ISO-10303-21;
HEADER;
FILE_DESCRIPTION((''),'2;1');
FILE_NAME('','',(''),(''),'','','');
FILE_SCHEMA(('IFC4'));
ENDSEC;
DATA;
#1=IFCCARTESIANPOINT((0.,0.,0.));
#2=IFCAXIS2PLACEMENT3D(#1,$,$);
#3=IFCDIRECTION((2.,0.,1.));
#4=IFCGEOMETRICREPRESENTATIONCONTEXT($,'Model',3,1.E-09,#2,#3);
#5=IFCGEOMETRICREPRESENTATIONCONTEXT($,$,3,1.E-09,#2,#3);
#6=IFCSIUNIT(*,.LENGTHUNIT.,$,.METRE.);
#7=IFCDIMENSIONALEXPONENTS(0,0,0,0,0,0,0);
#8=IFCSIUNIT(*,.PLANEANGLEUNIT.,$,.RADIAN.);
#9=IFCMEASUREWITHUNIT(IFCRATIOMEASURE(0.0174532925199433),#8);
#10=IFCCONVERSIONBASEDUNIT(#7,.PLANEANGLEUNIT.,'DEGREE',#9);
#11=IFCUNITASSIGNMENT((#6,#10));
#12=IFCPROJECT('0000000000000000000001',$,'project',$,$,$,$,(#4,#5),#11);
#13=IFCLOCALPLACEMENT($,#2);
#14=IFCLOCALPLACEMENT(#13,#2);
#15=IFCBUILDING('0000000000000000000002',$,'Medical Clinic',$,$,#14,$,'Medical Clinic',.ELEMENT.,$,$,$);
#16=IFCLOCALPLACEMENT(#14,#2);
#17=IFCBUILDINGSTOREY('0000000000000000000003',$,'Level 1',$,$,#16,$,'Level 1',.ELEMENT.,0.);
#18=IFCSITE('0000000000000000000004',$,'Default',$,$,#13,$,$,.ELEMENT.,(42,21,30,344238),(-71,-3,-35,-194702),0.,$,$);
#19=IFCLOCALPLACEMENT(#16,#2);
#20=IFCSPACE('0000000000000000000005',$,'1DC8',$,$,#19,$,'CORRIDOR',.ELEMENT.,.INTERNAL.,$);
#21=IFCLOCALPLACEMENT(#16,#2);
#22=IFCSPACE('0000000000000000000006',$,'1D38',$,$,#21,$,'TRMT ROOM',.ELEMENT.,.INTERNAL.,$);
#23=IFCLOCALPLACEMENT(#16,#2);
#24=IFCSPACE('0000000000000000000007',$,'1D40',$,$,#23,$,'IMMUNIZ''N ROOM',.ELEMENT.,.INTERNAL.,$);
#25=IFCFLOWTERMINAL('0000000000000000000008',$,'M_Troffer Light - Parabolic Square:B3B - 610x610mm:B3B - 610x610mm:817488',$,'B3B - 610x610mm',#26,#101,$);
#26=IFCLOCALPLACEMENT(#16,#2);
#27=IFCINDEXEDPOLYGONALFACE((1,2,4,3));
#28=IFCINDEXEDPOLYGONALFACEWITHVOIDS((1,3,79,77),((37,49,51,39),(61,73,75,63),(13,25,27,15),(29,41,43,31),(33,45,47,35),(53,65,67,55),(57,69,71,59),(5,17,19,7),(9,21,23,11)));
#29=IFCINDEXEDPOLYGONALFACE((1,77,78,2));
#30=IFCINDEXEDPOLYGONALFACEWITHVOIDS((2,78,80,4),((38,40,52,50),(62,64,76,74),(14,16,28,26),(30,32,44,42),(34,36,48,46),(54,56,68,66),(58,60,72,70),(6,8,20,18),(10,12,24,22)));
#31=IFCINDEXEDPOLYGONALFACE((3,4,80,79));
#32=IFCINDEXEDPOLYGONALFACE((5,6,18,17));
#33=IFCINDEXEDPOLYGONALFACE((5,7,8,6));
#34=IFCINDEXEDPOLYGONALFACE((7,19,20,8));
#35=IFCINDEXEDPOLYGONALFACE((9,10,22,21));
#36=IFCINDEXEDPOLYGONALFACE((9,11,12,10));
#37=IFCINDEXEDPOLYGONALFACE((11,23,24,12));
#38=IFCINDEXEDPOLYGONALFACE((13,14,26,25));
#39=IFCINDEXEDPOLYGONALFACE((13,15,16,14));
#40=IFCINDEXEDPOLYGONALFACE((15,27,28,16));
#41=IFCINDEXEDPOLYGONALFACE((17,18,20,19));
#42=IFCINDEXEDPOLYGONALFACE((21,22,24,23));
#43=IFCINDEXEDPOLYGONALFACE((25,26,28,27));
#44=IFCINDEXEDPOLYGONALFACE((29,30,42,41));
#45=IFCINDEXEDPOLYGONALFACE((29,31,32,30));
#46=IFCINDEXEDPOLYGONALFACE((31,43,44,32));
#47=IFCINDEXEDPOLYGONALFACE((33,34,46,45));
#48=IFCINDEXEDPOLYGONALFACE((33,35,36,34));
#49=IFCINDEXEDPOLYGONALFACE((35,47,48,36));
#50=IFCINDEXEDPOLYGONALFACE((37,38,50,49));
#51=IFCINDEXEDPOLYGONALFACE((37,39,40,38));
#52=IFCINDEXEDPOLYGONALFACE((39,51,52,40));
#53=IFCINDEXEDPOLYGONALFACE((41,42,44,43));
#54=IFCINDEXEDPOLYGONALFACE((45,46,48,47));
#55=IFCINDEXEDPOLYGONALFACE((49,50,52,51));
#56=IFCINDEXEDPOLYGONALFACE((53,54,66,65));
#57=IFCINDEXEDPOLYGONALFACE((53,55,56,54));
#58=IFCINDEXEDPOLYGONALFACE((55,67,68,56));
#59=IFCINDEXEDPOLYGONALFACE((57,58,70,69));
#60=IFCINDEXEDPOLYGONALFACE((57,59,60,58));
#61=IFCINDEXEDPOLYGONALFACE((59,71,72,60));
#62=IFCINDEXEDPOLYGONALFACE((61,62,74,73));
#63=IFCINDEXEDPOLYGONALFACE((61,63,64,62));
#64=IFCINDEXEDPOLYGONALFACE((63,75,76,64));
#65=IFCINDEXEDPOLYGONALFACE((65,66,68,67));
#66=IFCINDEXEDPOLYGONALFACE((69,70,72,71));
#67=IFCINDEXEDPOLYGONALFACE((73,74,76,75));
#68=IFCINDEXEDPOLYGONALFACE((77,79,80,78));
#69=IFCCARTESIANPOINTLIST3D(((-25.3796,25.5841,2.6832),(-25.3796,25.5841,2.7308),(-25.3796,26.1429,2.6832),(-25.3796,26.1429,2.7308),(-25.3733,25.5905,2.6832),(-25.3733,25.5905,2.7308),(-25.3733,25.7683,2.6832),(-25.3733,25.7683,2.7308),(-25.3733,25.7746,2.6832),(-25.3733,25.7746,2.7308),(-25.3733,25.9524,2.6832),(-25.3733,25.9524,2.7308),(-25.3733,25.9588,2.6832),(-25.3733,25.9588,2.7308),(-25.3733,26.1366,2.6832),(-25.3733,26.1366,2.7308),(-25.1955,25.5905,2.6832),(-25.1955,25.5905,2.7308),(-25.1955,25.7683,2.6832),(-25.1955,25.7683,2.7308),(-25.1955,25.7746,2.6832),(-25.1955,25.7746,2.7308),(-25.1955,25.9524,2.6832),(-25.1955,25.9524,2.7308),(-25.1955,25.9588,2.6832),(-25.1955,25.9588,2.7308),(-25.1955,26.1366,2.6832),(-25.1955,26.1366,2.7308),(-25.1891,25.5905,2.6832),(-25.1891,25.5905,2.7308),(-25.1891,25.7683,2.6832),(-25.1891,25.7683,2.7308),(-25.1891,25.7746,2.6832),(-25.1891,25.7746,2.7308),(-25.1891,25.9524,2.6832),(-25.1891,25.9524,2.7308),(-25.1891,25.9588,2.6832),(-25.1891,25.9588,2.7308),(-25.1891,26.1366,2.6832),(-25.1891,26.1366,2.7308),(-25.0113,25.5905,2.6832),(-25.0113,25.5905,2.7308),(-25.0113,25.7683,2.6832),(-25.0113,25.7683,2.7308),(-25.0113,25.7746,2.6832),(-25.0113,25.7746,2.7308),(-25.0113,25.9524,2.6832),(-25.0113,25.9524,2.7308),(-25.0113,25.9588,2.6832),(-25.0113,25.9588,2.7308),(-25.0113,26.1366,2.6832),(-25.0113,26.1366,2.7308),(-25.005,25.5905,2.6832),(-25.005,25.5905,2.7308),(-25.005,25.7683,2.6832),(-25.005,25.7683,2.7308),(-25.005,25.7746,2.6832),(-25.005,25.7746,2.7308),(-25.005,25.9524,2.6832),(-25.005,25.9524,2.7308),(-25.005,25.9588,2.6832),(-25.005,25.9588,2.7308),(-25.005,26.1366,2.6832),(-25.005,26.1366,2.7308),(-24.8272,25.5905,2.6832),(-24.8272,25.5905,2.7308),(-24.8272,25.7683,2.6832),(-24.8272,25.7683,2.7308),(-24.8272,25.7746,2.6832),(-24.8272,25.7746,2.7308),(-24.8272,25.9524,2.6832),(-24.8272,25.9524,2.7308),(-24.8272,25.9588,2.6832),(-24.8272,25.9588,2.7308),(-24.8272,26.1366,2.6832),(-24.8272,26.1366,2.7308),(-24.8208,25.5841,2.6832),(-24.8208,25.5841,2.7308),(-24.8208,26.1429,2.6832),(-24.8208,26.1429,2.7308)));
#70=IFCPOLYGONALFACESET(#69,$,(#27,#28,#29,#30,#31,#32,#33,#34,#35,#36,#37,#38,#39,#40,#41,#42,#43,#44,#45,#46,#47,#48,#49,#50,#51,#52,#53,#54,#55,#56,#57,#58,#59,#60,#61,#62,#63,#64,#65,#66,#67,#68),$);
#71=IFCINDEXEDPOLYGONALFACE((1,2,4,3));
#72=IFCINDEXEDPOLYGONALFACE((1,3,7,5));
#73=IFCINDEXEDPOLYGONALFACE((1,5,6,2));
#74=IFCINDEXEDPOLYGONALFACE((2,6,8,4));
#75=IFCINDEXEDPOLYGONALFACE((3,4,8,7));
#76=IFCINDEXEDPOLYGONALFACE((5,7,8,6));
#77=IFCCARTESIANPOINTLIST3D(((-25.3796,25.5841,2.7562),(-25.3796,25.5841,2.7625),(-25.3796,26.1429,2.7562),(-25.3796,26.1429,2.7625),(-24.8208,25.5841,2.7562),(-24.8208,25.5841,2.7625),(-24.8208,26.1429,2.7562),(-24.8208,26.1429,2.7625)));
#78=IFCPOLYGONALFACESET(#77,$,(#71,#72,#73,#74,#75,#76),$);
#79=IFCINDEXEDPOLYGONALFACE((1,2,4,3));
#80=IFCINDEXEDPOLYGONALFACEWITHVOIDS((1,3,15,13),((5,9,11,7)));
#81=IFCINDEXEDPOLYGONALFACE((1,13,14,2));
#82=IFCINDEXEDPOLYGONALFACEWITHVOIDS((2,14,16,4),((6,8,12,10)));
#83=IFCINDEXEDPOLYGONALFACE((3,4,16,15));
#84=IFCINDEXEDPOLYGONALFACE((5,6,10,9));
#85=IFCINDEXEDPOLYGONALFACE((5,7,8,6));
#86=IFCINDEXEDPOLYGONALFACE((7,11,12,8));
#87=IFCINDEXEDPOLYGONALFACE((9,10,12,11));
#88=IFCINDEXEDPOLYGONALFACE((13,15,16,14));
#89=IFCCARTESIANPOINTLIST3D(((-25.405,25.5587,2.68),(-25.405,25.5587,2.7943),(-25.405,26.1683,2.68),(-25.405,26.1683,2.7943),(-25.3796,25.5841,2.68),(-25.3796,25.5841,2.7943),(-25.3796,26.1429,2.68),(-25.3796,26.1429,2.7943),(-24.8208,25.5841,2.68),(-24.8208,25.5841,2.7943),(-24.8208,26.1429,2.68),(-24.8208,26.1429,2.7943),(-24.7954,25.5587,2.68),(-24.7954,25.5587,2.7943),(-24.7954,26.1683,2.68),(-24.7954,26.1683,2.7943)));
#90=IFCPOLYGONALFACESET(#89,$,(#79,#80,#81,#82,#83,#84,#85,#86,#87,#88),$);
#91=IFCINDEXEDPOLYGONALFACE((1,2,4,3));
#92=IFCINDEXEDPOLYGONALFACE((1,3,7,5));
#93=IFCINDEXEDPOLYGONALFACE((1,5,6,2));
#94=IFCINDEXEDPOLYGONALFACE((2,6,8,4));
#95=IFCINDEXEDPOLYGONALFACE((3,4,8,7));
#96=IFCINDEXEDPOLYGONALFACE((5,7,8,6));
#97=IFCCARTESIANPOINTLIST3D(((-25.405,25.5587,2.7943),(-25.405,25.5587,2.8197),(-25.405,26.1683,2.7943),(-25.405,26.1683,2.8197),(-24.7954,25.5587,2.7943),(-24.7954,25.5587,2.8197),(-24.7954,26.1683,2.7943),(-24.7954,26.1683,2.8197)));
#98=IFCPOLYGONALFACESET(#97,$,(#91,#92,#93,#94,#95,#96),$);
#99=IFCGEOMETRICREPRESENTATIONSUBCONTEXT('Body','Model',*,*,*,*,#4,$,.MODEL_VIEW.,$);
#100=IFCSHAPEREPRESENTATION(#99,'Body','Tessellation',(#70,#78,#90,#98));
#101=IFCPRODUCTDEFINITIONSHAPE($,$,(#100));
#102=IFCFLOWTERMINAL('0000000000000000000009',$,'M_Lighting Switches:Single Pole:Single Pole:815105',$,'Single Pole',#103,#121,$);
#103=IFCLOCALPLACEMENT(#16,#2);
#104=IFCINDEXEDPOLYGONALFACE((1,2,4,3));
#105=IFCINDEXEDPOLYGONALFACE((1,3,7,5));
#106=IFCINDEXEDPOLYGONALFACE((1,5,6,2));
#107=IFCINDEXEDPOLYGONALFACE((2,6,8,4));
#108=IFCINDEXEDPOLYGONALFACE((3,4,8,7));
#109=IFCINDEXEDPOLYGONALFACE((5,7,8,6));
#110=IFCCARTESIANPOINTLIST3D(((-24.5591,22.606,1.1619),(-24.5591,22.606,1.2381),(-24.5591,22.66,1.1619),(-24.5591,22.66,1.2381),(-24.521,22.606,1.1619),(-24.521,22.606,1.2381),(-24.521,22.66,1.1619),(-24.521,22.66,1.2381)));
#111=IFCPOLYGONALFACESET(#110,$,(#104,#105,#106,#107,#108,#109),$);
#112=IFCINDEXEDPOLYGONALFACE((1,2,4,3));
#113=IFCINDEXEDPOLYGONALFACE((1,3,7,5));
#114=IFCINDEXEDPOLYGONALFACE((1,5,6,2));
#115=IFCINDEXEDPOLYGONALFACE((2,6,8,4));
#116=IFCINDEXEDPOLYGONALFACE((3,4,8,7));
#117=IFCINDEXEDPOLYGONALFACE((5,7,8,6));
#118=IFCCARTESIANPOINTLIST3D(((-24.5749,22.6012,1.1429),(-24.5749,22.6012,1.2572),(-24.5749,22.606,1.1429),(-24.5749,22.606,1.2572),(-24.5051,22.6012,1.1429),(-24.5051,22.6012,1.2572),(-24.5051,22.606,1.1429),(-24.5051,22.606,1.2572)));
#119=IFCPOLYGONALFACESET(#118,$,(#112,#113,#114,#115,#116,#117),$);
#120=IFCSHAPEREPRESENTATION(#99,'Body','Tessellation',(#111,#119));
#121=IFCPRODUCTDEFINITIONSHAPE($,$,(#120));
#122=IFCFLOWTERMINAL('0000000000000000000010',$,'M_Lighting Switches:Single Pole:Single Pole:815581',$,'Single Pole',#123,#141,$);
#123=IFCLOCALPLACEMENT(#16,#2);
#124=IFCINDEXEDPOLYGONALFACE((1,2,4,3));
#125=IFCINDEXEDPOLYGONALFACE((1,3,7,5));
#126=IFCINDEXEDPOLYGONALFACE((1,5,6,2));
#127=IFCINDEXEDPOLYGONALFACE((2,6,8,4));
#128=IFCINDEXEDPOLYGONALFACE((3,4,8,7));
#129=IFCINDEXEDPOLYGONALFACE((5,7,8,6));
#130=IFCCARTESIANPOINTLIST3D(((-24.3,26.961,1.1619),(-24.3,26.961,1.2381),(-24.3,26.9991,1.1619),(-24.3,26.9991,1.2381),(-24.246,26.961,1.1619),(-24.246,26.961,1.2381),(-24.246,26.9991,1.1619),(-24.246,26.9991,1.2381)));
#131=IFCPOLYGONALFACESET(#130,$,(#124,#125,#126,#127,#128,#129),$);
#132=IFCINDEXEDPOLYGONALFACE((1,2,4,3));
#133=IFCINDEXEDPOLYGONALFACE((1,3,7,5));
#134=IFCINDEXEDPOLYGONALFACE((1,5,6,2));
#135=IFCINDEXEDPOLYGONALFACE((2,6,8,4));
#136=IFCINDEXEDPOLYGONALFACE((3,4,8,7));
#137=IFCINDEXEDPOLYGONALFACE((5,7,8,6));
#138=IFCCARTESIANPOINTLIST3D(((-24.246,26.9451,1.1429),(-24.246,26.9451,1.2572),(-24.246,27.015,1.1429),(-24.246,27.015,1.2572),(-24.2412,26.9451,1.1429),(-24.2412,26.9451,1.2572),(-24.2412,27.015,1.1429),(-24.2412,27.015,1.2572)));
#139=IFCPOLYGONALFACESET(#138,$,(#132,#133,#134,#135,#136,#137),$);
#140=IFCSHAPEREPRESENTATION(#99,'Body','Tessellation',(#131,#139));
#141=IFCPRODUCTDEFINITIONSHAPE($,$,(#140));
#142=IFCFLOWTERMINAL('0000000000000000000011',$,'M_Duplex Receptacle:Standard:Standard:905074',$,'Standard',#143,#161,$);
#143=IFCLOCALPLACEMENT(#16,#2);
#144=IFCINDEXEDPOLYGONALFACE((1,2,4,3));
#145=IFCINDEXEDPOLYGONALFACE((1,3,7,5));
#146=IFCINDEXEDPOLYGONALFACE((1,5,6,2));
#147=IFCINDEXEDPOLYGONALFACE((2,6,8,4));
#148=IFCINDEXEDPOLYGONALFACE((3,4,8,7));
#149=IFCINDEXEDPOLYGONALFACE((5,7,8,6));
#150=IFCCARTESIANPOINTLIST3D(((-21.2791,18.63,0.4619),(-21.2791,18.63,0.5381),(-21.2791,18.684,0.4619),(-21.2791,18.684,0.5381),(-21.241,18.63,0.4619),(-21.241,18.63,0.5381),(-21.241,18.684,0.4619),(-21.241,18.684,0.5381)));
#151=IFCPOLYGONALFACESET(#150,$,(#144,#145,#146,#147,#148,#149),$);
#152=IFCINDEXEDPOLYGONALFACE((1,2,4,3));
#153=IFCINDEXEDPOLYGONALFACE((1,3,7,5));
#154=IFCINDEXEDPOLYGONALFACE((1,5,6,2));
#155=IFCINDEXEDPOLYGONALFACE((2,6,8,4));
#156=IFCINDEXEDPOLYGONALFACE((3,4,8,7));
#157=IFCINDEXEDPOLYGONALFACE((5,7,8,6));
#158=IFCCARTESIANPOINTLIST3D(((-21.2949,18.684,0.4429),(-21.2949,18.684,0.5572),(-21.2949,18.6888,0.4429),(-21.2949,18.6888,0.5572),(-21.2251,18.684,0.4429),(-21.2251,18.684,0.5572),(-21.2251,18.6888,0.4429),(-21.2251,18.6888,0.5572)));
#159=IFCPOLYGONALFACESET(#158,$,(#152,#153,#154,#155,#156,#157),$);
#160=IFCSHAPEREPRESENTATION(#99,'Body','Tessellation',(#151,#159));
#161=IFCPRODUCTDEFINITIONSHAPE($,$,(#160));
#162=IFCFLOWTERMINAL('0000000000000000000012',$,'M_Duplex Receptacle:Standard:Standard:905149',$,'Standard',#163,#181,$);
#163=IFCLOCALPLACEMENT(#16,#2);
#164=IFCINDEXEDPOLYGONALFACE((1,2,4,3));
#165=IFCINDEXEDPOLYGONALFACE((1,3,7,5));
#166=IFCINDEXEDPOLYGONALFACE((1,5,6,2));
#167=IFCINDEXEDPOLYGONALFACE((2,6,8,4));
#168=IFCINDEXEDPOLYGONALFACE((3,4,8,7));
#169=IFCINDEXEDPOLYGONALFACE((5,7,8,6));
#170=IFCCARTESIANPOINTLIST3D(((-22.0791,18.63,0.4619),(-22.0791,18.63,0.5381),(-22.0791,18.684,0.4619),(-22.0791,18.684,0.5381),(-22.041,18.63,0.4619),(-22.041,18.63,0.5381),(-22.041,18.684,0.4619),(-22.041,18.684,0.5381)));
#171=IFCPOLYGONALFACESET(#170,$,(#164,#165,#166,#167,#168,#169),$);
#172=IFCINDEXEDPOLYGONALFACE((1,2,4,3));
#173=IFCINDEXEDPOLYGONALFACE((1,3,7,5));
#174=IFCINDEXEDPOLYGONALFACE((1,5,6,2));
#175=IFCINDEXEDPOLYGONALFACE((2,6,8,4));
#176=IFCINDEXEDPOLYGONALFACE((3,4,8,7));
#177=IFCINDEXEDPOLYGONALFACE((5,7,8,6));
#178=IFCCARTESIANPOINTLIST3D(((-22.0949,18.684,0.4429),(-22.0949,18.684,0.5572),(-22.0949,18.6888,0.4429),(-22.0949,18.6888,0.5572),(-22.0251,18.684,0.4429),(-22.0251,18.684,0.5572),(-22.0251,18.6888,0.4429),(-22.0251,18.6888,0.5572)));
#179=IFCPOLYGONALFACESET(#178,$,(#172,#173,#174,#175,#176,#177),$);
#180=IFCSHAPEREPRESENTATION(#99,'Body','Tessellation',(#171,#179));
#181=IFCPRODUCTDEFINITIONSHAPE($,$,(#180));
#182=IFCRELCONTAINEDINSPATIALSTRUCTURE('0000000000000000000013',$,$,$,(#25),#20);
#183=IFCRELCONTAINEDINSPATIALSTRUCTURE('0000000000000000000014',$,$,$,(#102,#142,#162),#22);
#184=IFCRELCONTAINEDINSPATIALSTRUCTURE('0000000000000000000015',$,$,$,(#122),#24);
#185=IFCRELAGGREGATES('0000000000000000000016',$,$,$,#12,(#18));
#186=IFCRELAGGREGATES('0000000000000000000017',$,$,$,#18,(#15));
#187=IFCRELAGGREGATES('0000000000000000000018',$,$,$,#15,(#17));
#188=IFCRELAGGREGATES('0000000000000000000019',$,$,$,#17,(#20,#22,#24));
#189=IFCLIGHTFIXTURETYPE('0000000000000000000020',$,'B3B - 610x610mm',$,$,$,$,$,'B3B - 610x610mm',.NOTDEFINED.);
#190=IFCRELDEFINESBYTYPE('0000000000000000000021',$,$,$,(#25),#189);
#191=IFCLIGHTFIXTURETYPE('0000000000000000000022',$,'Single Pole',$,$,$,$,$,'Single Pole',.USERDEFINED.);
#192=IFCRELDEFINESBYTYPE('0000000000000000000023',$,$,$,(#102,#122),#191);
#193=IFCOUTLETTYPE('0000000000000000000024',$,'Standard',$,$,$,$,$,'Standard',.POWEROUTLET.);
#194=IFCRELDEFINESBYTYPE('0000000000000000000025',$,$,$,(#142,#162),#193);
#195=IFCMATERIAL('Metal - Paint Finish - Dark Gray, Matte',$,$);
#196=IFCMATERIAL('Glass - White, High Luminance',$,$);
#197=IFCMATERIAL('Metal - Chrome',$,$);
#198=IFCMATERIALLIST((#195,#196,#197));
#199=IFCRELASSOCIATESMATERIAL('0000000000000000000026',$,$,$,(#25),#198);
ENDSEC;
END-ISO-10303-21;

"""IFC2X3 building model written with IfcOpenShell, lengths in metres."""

from ifc_helpers import new_model, entity, si_unit, converted_unit, direction, frame, frame_2d, origin, origin_2d_with_axis, place, context, subcontext, project, spatial, polyline, rectangle, outline, extrude, source, transform, mapped, material, material_list, type_object, type_shapes, element, save


model = new_model("IFC2X3")

# Units and contexts
model_context = context("Model", 3, precision=1e-09, world=origin(), true_north=direction((2.0, 0.0, 1.0)))
context_of_model = context(None, 3, precision=1e-09, world=origin(), true_north=direction((2.0, 0.0, 1.0)))
body_context = subcontext(model_context, "Body", "Model", "MODEL_VIEW")
ifc_project = project(units=[si_unit("LENGTHUNIT", "METRE"), converted_unit("PLANEANGLEUNIT", "DEGREE", entity("IfcRatioMeasure", 0.0174532925199433), si_unit("PLANEANGLEUNIT", "RADIAN"), dimensions=[0, 0, 0, 0, 0, 0, 0])], contexts=[model_context, context_of_model])

# Site, building, storey
site_placement = place(None, origin())
site = spatial("IfcSite", under=ifc_project, at=site_placement, Name="Default", CompositionType="ELEMENT", RefLatitude=(42, 21, 30, 344238), RefLongitude=(-71, -3, -35, -194702), RefElevation=0.0)
building_placement = place(site_placement, origin())
building = spatial("IfcBuilding", under=site, at=building_placement, Name="Medical Clinic", LongName="Medical Clinic", CompositionType="ELEMENT")
storey_placement = place(building_placement, origin())
storey = spatial("IfcBuildingStorey", under=building, at=storey_placement, Name="Level 1", LongName="Level 1", CompositionType="ELEMENT", Elevation=0.0)

# Shared definitions
ifc_material_1 = material(Name="Metal - Paint Finish - Dark Gray, Matte")
ifc_material_2 = material(Name="Glass - White, High Luminance")
ifc_material_3 = material(Name="Metal - Chrome")

# Shared definitions
space_1_placement = place(storey_placement, origin())
space_1 = spatial("IfcSpace", under=storey, at=space_1_placement, Name="1DC8", LongName="CORRIDOR", CompositionType="ELEMENT", InteriorOrExteriorSpace="INTERNAL")

# Flow terminal
ifc_material_list_1 = material_list([ifc_material_1, ifc_material_2, ifc_material_3])
light_fixture_type_1 = type_object("IfcLightFixtureType", Name="B3B - 610x610mm", ElementType="B3B - 610x610mm", PredefinedType="NOTDEFINED")
shared_shape_1 = source(origin(), body_context, "Body", "SweptSolid", [
    extrude(outline(polyline([(-0.2794, -0.2794), (0.2794, -0.2794), (0.2794, 0.2794), (-0.2794, 0.2794), (-0.2794, -0.2794)]), holes=[polyline([(-0.0952, 0.0953), (-0.273, 0.0953), (-0.273, 0.2731), (-0.0952, 0.2731), (-0.0952, 0.0953)]), polyline([(0.2731, 0.0953), (0.0953, 0.0953), (0.0953, 0.2731), (0.2731, 0.2731), (0.2731, 0.0953)]), polyline([(-0.0889, 0.2731), (0.0889, 0.2731), (0.0889, 0.0953), (-0.0889, 0.0953), (-0.0889, 0.2731)]), polyline([(0.2731, -0.273), (0.0953, -0.273), (0.0953, -0.0952), (0.2731, -0.0952), (0.2731, -0.273)]), polyline([(0.0889, -0.273), (-0.0889, -0.273), (-0.0889, -0.0952), (0.0889, -0.0952), (0.0889, -0.273)]), polyline([(-0.0952, -0.273), (-0.273, -0.273), (-0.273, -0.0952), (-0.0952, -0.0952), (-0.0952, -0.273)]), polyline([(-0.0952, -0.0889), (-0.273, -0.0889), (-0.273, 0.0889), (-0.0952, 0.0889), (-0.0952, -0.0889)]), polyline([(0.0889, -0.0889), (-0.0889, -0.0889), (-0.0889, 0.0889), (0.0889, 0.0889), (0.0889, -0.0889)]), polyline([(0.2731, -0.0889), (0.0953, -0.0889), (0.0953, 0.0889), (0.2731, 0.0889), (0.2731, -0.0889)])]), frame((0.0, -0.3048, -0.0508), z_axis=(0.0, 0.0, 1.0), x_axis=(-1.0, 0.0, 0.0)), (0.0, 0.0, 1.0), 0.0476),
    extrude(rectangle(XDim=0.5588, YDim=0.5588, at=origin_2d_with_axis()), frame((0.0, -0.3048, -0.0825), z_axis=(0.0, 0.0, 1.0), x_axis=(-1.0, 0.0, 0.0)), (0.0, 0.0, 1.0), 0.0064),
    extrude(outline(polyline([(-0.3048, -0.3048), (0.3048, -0.3048), (0.3048, 0.3048), (-0.3048, 0.3048), (-0.3048, -0.3048)]), holes=[polyline([(0.2794, 0.2794), (0.2794, -0.2794), (-0.2794, -0.2794), (-0.2794, 0.2794), (0.2794, 0.2794)])]), frame((0.0, -0.3048, -0.1143)), (0.0, 0.0, 1.0), 0.1143),
    extrude(rectangle(XDim=0.6096, YDim=0.6096, at=origin_2d_with_axis()), frame((0.0, -0.3048, -0.1397), z_axis=(0.0, 0.0, 1.0), x_axis=(-1.0, 0.0, 0.0)), (0.0, 0.0, 1.0), 0.0254),
])
type_shapes(light_fixture_type_1, [shared_shape_1])
flow_terminal_1_placement = place(space_1_placement, frame((-25.1002, 25.5587, 2.68), z_axis=(0.0, 0.0, -1.0), x_axis=(1.0, 0.0, 0.0)))
element("IfcFlowTerminal", 1, at=flow_terminal_1_placement, inside=space_1, type_object=light_fixture_type_1, material=ifc_material_list_1, Name="M_Troffer Light - Parabolic Square:B3B - 610x610mm:B3B - 610x610mm:817488", ObjectType="B3B - 610x610mm", context=body_context, shape_type="MappedRepresentation", body=[
    mapped(shared_shape_1, transform((0.0, 0.0, 0.0), scale=1.0)),
])

# Shared definitions
space_2_placement = place(storey_placement, origin())
space_2 = spatial("IfcSpace", under=storey, at=space_2_placement, Name="1D38", LongName="TRMT ROOM", CompositionType="ELEMENT", InteriorOrExteriorSpace="INTERNAL")

# Flow terminal
light_fixture_type_2 = type_object("IfcLightFixtureType", Name="Single Pole", ElementType="Single Pole", PredefinedType="USERDEFINED")
shared_shape_2 = source(origin(), body_context, "Body", "SweptSolid", [
    extrude(rectangle(XDim=0.0381, YDim=0.0762, at=origin_2d_with_axis()), frame((0.0, 0.0, -0.054), z_axis=(0.0, 0.0, 1.0), x_axis=(-1.0, 0.0, 0.0)), (0.0, 0.0, 1.0), 0.054),
    extrude(rectangle(XDim=0.0698, YDim=0.1143, at=frame_2d((0.0, 0.0), x_axis=(1.0, 0.0))), frame((0.0, 0.0, 0.0), z_axis=(0.0, 0.0, 1.0), x_axis=(-1.0, 0.0, 0.0)), (0.0, 0.0, 1.0), 0.0048),
])
type_shapes(light_fixture_type_2, [shared_shape_2])
flow_terminal_2_placement = place(space_2_placement, frame((-24.54, 22.606, 1.2), z_axis=(0.0, -1.0, 0.0), x_axis=(1.0, 0.0, 0.0)))
element("IfcFlowTerminal", 2, at=flow_terminal_2_placement, inside=space_2, type_object=light_fixture_type_2, Name="M_Lighting Switches:Single Pole:Single Pole:815105", ObjectType="Single Pole", context=body_context, shape_type="MappedRepresentation", body=[
    mapped(shared_shape_2, transform((0.0, 0.0, 0.0), scale=1.0)),
])

# Shared definitions
space_3_placement = place(storey_placement, origin())
space_3 = spatial("IfcSpace", under=storey, at=space_3_placement, Name="1D40", LongName="IMMUNIZ'N ROOM", CompositionType="ELEMENT", InteriorOrExteriorSpace="INTERNAL")

# Flow terminals
flow_terminal_3_placement = place(space_3_placement, frame((-24.246, 26.9801, 1.2), z_axis=(1.0, 0.0, 0.0), x_axis=(0.0, 1.0, 0.0)))
element("IfcFlowTerminal", 3, at=flow_terminal_3_placement, inside=space_3, type_object=light_fixture_type_2, Name="M_Lighting Switches:Single Pole:Single Pole:815581", ObjectType="Single Pole", context=body_context, shape_type="MappedRepresentation", body=[
    mapped(shared_shape_2, transform((0.0, 0.0, 0.0), scale=1.0)),
])
outlet_type = type_object("IfcOutletType", Name="Standard", ElementType="Standard", PredefinedType="POWEROUTLET")
shared_shape_3 = source(origin(), body_context, "Body", "SweptSolid", [
    extrude(rectangle(XDim=0.0381, YDim=0.0762, at=origin_2d_with_axis()), frame((0.0, 0.0, -0.054), z_axis=(0.0, 0.0, 1.0), x_axis=(-1.0, 0.0, 0.0)), (0.0, 0.0, 1.0), 0.054),
    extrude(rectangle(XDim=0.0698, YDim=0.1143, at=frame_2d((0.0, 0.0), x_axis=(1.0, 0.0))), frame((0.0, 0.0, 0.0), z_axis=(0.0, 0.0, 1.0), x_axis=(-1.0, 0.0, 0.0)), (0.0, 0.0, 1.0), 0.0048),
])
type_shapes(outlet_type, [shared_shape_3])
for number, where, z_axis, x_axis, name in (
    (4, (-21.26, 18.684, 0.5), (0.0, 1.0, 0.0), (-1.0, 0.0, 0.0), "M_Duplex Receptacle:Standard:Standard:905074"),
    (5, (-22.06, 18.684, 0.5), (0.0, 1.0, 0.0), (-1.0, 0.0, 0.0), "M_Duplex Receptacle:Standard:Standard:905149"),
):
    element("IfcFlowTerminal", number, at=place(space_2_placement, frame(where, z_axis=z_axis, x_axis=x_axis)), inside=space_2, type_object=outlet_type, Name=name, ObjectType="Standard", context=body_context, shape_type="MappedRepresentation", body=[
        mapped(shared_shape_3, transform((0.0, 0.0, 0.0), scale=1.0)),
    ])

save(model, "model.ifc")
